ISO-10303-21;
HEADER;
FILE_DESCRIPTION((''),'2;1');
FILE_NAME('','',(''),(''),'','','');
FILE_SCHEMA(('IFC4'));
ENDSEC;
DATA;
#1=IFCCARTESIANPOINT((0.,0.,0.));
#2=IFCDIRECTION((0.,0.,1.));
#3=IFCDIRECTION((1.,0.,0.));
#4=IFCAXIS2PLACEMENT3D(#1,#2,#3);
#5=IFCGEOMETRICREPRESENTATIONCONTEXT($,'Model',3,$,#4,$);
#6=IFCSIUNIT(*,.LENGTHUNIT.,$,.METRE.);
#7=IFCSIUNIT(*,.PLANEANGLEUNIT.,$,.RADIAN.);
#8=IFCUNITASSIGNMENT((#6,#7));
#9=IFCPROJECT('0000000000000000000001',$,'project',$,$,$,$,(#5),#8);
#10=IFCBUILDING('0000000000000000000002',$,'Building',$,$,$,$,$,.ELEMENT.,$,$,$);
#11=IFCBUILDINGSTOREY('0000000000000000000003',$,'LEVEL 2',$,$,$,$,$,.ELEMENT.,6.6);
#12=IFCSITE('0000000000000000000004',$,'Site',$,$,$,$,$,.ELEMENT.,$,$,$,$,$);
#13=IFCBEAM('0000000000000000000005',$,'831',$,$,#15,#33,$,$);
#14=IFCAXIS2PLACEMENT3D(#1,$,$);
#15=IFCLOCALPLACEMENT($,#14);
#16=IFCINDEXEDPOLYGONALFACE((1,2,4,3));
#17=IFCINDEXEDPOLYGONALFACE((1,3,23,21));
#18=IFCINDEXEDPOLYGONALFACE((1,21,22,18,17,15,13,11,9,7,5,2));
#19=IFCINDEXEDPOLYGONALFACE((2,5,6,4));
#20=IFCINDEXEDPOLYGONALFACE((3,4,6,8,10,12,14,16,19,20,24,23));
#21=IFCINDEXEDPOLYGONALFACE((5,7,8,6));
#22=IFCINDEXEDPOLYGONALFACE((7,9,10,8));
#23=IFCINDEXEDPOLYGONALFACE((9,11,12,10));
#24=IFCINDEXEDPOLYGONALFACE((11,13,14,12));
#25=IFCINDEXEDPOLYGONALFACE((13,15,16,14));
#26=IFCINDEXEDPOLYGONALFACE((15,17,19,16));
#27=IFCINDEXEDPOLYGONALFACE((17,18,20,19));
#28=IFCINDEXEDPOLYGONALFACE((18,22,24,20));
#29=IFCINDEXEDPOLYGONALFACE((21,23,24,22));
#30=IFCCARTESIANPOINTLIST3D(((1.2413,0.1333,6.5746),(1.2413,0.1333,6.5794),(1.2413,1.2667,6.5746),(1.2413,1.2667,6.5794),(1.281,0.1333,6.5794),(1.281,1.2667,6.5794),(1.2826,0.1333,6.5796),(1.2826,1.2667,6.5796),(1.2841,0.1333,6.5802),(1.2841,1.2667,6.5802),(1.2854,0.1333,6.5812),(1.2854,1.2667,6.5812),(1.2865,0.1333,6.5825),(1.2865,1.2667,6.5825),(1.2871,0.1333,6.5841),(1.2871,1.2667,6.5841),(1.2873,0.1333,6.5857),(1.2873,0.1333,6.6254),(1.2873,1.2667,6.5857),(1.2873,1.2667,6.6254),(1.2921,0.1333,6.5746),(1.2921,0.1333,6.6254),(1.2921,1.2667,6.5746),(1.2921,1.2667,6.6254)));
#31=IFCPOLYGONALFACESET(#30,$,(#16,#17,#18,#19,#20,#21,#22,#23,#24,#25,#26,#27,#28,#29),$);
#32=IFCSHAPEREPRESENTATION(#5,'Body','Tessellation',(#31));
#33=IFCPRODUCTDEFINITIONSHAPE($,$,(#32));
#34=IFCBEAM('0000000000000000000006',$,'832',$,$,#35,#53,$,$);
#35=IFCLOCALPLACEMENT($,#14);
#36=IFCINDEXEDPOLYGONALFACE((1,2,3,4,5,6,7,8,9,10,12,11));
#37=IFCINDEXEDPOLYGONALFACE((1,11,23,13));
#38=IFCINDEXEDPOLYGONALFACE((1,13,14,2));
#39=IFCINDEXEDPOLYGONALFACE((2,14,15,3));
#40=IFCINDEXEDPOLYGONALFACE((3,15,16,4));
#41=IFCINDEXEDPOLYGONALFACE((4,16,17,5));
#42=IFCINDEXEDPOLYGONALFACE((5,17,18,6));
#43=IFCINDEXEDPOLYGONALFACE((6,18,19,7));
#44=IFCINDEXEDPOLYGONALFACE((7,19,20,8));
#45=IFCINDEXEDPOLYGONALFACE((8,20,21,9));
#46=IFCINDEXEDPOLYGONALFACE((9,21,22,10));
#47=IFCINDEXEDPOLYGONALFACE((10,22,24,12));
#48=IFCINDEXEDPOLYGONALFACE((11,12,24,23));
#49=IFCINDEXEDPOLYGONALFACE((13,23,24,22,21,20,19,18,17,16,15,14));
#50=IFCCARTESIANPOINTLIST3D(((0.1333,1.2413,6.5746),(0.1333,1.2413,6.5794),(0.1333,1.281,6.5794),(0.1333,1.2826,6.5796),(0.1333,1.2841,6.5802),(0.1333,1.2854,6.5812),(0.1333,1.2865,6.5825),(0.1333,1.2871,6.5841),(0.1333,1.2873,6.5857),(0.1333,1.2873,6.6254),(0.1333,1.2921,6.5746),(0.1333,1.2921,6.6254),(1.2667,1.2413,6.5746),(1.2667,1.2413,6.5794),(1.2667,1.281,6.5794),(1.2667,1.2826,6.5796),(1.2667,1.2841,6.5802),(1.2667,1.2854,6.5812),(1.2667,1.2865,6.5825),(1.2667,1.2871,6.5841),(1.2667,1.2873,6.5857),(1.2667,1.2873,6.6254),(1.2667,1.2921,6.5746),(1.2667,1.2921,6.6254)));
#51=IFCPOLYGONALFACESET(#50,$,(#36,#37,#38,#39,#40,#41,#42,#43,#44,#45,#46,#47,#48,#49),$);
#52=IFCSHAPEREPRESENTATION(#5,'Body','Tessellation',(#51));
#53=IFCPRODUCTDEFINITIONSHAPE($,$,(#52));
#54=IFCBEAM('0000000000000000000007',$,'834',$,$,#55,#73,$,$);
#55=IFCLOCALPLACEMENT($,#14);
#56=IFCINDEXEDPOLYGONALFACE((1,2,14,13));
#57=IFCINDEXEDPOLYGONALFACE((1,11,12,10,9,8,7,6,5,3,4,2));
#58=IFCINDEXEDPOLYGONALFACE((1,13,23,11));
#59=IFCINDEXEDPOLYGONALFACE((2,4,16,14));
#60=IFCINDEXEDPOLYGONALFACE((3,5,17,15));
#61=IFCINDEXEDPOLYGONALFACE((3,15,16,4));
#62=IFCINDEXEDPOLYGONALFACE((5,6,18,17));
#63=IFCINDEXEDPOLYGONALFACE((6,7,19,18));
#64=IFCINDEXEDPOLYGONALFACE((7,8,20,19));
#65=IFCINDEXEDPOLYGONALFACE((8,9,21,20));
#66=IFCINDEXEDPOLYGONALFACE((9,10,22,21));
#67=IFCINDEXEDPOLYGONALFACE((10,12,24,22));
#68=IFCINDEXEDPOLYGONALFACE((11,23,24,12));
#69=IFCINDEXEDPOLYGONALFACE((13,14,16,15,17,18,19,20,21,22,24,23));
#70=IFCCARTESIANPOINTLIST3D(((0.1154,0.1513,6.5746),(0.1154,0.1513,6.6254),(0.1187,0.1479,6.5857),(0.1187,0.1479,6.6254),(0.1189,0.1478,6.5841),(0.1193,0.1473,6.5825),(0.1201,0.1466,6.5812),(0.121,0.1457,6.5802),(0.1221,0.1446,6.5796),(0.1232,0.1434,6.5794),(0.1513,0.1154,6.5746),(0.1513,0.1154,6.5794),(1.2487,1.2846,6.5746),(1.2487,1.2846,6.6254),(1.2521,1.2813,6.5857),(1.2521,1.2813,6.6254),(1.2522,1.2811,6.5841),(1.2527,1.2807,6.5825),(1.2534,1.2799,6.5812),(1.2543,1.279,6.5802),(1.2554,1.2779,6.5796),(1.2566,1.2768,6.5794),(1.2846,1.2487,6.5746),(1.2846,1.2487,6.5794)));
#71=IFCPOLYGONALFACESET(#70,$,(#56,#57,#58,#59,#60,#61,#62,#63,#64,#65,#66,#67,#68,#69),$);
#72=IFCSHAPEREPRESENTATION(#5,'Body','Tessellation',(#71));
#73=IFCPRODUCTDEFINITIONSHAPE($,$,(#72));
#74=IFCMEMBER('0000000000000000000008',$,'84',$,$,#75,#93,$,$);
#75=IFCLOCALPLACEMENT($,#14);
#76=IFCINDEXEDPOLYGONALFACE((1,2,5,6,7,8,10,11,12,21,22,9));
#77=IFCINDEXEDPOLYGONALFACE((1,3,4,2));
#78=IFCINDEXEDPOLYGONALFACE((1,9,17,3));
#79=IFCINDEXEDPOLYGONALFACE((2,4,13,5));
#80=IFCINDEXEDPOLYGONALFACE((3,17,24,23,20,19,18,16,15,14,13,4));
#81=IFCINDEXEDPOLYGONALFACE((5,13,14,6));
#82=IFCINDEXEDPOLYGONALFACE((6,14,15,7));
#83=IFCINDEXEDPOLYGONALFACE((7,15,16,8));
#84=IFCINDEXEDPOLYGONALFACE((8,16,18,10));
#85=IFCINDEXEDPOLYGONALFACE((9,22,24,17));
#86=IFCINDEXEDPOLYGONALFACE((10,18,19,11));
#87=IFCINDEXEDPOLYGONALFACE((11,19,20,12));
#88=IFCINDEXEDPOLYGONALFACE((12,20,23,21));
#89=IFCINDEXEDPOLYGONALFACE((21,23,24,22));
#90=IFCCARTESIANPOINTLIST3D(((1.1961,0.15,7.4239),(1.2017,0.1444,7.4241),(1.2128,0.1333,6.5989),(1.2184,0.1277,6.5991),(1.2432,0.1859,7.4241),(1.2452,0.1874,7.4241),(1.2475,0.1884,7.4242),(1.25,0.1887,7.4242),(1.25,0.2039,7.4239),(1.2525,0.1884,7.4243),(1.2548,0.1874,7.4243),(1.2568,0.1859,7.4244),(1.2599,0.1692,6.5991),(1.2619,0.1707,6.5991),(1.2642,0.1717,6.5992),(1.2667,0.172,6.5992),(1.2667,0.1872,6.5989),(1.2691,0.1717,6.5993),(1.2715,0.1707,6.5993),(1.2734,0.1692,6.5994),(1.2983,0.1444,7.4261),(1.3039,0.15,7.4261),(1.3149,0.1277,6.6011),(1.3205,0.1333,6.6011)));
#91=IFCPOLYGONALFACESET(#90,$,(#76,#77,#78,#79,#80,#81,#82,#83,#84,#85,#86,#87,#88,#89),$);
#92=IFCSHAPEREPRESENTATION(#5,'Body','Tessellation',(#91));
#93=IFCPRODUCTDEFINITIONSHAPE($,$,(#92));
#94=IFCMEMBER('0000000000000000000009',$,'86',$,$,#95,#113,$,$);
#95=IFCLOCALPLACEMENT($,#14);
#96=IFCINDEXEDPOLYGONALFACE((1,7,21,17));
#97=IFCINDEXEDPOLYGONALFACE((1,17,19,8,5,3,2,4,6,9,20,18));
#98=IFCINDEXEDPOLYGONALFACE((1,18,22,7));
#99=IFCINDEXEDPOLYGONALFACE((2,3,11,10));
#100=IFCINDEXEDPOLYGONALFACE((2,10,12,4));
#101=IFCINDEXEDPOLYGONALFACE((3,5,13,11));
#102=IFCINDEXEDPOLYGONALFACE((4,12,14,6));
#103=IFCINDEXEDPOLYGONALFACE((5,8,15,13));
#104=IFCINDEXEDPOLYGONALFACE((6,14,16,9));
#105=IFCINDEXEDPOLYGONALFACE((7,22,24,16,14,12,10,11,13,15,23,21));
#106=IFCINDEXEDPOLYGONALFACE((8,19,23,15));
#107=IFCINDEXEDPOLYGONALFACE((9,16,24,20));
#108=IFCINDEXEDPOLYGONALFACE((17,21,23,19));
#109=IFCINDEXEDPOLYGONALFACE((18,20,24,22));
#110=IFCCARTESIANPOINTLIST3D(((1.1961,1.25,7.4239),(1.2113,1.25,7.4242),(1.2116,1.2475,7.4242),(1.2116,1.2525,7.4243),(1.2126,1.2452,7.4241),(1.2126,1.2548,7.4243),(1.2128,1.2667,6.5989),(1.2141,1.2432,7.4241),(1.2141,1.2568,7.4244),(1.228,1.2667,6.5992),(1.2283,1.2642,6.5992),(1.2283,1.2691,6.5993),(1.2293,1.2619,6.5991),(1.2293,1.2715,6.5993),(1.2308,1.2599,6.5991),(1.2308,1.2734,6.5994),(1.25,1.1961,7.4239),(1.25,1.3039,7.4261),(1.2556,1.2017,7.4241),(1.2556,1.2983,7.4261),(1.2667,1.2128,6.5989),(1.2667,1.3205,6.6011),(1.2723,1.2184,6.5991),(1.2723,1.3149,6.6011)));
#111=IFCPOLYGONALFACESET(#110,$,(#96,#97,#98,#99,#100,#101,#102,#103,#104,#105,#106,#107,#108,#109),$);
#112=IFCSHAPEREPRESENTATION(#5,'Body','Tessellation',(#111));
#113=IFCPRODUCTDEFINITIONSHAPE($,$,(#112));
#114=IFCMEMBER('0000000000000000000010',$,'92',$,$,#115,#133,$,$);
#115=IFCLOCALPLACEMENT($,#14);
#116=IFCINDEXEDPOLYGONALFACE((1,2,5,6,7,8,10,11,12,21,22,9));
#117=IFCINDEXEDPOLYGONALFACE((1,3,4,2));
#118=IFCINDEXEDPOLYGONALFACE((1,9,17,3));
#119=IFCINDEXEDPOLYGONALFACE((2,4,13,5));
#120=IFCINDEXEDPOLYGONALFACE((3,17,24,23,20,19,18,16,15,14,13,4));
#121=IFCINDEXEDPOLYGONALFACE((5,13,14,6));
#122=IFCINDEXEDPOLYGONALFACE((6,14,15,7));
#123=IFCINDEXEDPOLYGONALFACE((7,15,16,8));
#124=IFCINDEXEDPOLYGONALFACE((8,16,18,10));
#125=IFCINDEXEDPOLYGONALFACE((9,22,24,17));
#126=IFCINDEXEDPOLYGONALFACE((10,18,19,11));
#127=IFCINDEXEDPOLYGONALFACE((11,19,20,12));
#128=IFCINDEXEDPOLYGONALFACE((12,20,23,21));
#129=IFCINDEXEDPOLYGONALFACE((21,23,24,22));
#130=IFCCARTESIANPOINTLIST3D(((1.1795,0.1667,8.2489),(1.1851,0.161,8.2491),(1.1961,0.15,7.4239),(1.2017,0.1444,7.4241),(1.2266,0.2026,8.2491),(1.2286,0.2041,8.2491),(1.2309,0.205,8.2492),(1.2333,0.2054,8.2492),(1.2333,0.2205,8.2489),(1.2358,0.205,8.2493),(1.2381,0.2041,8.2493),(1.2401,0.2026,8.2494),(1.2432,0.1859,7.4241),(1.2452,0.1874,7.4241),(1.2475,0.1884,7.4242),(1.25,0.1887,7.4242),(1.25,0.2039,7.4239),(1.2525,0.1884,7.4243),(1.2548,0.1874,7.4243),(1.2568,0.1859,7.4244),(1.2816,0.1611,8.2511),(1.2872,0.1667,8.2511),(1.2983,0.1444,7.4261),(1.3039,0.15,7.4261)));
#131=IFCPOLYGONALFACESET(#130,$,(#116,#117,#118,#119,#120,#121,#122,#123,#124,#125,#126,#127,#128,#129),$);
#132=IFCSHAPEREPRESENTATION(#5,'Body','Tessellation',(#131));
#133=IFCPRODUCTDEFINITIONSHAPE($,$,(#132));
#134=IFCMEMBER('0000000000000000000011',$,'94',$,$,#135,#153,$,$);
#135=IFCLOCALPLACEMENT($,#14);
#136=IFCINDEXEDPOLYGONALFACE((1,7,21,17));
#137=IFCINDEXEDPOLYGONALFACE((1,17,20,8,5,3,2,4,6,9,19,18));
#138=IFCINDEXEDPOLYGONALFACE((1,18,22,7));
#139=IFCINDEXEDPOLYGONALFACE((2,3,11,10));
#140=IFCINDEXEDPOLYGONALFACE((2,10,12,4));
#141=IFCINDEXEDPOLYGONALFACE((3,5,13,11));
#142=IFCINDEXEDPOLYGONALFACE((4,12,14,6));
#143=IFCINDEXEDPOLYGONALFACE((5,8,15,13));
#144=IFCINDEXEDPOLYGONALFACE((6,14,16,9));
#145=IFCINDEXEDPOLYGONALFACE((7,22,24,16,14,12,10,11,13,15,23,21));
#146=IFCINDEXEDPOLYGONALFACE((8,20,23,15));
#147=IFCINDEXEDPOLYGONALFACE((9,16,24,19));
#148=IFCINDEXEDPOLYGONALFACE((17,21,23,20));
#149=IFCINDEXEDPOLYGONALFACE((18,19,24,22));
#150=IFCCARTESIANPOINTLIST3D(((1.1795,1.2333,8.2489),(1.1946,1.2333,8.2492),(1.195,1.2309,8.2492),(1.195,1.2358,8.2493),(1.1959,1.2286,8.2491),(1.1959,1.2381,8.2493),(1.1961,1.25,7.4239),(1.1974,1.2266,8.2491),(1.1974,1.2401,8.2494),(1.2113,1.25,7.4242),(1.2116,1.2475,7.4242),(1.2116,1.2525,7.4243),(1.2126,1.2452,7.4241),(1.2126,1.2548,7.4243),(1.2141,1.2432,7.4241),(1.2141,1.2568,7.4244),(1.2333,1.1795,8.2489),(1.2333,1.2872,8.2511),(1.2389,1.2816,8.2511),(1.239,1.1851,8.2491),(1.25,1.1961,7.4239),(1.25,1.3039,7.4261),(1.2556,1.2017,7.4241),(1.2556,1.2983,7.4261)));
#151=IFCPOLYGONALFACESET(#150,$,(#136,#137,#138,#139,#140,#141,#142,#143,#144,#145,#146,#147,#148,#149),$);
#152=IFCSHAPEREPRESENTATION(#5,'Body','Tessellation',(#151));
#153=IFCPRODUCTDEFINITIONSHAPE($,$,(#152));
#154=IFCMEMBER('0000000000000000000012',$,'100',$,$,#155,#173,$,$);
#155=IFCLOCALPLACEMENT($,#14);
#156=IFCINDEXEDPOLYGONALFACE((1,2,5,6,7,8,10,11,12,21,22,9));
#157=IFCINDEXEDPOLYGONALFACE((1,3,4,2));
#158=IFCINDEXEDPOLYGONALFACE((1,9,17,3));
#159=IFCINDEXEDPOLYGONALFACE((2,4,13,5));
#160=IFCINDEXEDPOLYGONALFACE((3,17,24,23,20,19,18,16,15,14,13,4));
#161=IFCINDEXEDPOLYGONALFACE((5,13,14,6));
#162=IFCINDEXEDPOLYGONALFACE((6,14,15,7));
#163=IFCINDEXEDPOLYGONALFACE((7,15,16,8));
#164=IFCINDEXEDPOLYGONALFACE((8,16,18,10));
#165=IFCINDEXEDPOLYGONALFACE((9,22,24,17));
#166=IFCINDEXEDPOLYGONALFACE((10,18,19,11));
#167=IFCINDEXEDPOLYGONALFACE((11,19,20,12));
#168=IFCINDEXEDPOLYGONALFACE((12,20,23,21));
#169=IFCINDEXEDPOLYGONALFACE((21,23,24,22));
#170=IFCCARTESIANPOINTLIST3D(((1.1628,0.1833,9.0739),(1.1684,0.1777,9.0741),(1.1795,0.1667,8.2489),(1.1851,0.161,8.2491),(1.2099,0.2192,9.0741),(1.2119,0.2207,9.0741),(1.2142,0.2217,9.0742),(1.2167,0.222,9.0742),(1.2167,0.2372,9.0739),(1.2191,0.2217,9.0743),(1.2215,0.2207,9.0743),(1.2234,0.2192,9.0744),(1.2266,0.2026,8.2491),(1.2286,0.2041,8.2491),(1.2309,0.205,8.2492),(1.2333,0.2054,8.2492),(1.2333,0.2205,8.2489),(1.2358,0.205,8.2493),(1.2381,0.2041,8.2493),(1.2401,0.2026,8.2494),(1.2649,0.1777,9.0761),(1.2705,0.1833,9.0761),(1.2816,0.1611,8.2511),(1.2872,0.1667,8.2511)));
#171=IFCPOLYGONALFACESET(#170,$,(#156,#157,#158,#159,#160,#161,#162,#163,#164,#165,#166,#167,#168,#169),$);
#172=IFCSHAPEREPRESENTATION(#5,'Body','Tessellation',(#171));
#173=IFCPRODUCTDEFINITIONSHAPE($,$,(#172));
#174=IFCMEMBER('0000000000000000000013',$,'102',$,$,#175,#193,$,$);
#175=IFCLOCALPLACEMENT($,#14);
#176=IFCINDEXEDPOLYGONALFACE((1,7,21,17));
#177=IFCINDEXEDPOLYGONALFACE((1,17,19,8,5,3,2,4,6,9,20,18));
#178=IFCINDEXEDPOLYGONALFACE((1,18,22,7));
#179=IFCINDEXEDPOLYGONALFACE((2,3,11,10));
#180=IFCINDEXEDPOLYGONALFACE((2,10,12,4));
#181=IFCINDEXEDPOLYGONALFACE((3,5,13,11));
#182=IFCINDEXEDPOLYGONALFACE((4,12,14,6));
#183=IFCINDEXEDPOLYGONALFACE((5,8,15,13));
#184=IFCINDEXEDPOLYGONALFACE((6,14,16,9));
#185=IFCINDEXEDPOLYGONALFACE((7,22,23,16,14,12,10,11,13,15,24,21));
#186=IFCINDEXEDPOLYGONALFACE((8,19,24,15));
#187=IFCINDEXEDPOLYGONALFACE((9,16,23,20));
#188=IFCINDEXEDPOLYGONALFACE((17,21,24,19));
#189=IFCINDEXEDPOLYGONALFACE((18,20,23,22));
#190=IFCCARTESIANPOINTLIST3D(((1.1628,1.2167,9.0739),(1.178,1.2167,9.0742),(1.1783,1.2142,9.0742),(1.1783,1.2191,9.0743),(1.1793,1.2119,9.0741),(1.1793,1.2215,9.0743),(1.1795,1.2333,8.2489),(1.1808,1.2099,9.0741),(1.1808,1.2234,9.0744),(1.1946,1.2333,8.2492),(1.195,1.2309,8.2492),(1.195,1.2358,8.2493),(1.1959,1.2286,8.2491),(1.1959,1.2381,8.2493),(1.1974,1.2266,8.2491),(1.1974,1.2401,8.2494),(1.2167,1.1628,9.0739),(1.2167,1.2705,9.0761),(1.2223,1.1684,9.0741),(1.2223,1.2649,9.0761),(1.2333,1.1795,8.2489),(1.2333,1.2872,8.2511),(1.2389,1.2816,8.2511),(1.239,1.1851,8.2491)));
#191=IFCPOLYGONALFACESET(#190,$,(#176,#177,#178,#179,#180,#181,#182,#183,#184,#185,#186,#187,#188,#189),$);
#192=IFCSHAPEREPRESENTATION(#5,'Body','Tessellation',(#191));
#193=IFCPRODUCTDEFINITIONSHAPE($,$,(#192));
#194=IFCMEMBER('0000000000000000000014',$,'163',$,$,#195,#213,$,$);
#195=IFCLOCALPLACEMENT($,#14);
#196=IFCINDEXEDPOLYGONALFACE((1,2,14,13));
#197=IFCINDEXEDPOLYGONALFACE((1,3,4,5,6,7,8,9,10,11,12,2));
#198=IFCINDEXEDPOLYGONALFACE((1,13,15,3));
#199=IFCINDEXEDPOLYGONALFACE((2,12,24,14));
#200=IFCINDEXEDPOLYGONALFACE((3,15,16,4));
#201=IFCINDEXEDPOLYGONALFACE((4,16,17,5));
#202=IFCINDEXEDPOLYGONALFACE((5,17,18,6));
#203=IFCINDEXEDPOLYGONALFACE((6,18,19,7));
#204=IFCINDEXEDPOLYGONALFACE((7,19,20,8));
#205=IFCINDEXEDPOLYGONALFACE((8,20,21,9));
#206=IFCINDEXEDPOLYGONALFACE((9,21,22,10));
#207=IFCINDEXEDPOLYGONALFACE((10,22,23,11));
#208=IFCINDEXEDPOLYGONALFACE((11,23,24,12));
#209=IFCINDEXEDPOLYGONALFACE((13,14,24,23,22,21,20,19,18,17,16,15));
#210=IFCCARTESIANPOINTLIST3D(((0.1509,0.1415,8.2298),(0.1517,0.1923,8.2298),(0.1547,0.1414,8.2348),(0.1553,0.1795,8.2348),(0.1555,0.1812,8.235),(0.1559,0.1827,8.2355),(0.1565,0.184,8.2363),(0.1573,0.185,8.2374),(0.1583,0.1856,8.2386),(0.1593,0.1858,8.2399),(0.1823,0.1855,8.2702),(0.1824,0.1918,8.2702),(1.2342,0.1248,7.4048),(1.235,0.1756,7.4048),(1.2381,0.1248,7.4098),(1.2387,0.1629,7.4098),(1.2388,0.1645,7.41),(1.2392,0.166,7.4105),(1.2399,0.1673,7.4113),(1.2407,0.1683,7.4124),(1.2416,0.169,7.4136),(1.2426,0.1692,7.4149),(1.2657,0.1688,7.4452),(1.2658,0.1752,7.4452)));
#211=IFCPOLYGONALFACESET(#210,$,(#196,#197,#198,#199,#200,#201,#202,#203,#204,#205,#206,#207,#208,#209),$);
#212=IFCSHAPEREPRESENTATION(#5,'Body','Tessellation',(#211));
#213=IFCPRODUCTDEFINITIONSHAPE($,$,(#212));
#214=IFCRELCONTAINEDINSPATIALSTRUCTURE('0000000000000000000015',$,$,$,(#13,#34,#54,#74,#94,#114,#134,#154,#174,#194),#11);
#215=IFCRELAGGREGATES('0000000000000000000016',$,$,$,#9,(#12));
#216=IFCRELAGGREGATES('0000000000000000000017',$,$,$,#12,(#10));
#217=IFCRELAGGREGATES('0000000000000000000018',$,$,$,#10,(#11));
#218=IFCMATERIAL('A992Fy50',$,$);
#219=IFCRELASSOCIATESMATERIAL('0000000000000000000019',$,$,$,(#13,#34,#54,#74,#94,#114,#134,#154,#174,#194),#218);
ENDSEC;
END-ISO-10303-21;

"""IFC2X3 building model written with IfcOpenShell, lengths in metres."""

from ifc_helpers import new_model, si_unit, frame, origin_with_axes, origin_2d_with_axis, place, context, project, spatial, l_section, extrude, material, element, save


model = new_model("IFC2X3")

# Units and contexts
model_context = context("Model", 3, world=origin_with_axes())
ifc_project = project(units=[si_unit("LENGTHUNIT", "METRE"), si_unit("PLANEANGLEUNIT", "RADIAN")], contexts=[model_context])

# Site, building, storey
site = spatial("IfcSite", under=ifc_project, Name="Site", CompositionType="ELEMENT")
building = spatial("IfcBuilding", under=site, Name="Building", CompositionType="ELEMENT")
storey = spatial("IfcBuildingStorey", under=building, Name="LEVEL 2", CompositionType="ELEMENT", Elevation=6.6)

# Beams
ifc_material = material(Name="A992Fy50")
for number, where, z_axis, x_axis, name in (
    (1, (1.2667, 0.1333, 6.6), (0.0, 1.0, 0.0), (-1.0, 0.0, 0.0), "831"),
    (2, (1.2667, 1.2667, 6.6), (-1.0, 0.0, 0.0), (0.0, -1.0, 0.0), "832"),
):
    element("IfcBeam", number, at=place(None, frame(where, z_axis=z_axis, x_axis=x_axis)), inside=storey, material=ifc_material, Name=name, context=model_context, shape_type="SweptSolid", body=[
        extrude(l_section(Depth=0.0508, Width=0.0508, Thickness=0.0048, FilletRadius=0.0063, at=origin_2d_with_axis()), origin_with_axes(), (0.0, 0.0, 1.0), 1.1333),
    ])
beam_placement = place(None, frame((1.2667, 1.2667, 6.6), z_axis=(-0.707107, -0.707107, 0.0), x_axis=(0.707107, -0.707107, 0.0)))
element("IfcBeam", 3, at=beam_placement, inside=storey, material=ifc_material, Name="834", context=model_context, shape_type="SweptSolid", body=[
    extrude(l_section(Depth=0.0508, Width=0.0508, Thickness=0.0048, FilletRadius=0.0063, at=origin_2d_with_axis()), origin_with_axes(), (0.0, 0.0, 1.0), 1.6028),
])

# Members
for number, where, z_axis, x_axis, name in (
    (4, (1.2667, 0.1333, 6.6), (-0.020194, 0.020194, 0.999592), (-0.707107, -0.707107, 0.0), "84"),
    (5, (1.2667, 1.2667, 6.6), (-0.020194, -0.020194, 0.999592), (0.707107, -0.707107, 0.0), "86"),
    (6, (1.25, 0.15, 7.425), (-0.020194, 0.020194, 0.999592), (-0.707107, -0.707107, 0.0), "92"),
    (7, (1.25, 1.25, 7.425), (-0.020194, -0.020194, 0.999592), (0.707107, -0.707107, 0.0), "94"),
    (8, (1.2333, 0.1667, 8.25), (-0.020194, 0.020194, 0.999592), (-0.707107, -0.707107, 0.0), "100"),
    (9, (1.2333, 1.2333, 8.25), (-0.020194, -0.020194, 0.999592), (0.707107, -0.707107, 0.0), "102"),
):
    element("IfcMember", number, at=place(None, frame(where, z_axis=z_axis, x_axis=x_axis)), inside=storey, material=ifc_material, Name=name, context=model_context, shape_type="SweptSolid", body=[
        extrude(l_section(Depth=0.0762, Width=0.0762, Thickness=0.0079, FilletRadius=0.0096, at=origin_2d_with_axis()), origin_with_axes(), (0.0, 0.0, 1.0), 0.8253),
    ])
member_1_placement = place(None, frame((1.25, 0.15, 7.425), z_axis=(-0.795513, 0.012239, 0.605813), x_axis=(-0.015383, -0.999882, 0.0)))
element("IfcMember", 10, at=member_1_placement, inside=storey, material=ifc_material, Name="163", context=model_context, shape_type="SweptSolid", body=[
    extrude(l_section(Depth=0.0508, Width=0.0508, Thickness=0.0063, FilletRadius=0.0063, at=origin_2d_with_axis()), origin_with_axes(), (0.0, 0.0, 1.0), 1.3618),
])

save(model, "model.ifc")
